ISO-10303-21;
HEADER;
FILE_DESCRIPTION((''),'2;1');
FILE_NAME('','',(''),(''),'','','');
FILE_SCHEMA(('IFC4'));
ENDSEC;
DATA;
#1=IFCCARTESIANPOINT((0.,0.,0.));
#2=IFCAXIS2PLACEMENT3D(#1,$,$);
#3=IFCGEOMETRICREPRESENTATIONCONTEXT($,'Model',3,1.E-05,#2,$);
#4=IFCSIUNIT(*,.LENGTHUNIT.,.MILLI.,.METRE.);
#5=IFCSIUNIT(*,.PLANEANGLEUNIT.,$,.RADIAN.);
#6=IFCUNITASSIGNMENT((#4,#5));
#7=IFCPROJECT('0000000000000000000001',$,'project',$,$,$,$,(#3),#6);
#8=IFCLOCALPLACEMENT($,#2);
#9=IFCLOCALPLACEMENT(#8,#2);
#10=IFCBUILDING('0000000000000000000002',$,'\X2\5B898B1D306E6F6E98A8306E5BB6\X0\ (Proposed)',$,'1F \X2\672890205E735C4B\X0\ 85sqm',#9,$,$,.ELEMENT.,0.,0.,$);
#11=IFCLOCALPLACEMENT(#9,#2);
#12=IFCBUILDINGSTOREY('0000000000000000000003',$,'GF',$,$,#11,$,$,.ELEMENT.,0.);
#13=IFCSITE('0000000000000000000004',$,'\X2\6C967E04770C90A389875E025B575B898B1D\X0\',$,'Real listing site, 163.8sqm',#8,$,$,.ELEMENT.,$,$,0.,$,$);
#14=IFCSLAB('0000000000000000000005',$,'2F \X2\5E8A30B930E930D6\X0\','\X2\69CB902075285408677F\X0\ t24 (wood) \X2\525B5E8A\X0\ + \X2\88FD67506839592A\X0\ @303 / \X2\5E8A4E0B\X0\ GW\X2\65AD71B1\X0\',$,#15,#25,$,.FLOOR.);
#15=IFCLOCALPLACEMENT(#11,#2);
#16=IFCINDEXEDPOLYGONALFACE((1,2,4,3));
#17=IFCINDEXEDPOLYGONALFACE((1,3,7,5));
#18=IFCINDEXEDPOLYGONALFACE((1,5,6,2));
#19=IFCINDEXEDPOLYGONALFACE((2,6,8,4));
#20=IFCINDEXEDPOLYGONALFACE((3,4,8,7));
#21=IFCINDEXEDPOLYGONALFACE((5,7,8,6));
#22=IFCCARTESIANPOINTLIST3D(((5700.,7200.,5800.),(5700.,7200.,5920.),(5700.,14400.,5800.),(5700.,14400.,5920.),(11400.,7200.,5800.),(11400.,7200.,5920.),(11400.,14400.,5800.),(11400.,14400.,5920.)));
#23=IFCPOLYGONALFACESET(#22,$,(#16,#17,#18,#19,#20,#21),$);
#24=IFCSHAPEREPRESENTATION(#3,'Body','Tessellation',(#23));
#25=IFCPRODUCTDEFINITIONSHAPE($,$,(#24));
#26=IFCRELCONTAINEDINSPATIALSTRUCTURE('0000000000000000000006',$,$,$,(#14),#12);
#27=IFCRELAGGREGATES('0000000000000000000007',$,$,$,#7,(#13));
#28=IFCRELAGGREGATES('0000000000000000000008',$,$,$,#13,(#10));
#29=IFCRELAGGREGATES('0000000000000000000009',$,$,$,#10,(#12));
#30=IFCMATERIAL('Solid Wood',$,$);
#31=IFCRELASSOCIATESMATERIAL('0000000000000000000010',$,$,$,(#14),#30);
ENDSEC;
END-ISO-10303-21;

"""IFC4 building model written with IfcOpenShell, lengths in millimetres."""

from ifc_helpers import new_model, si_unit, frame, frame_2d, origin, place, context, project, spatial, rectangle, extrude, material, element, save


model = new_model("IFC4")

# Units and contexts
model_context = context("Model", 3, precision=1e-05, world=origin())
ifc_project = project(units=[si_unit("LENGTHUNIT", "METRE", prefix="MILLI"), si_unit("PLANEANGLEUNIT", "RADIAN")], contexts=[model_context])

# Site, building, storey
site_placement = place(None, origin())
site = spatial("IfcSite", under=ifc_project, at=site_placement, Name="沖縄県那覇市字安謝", ObjectType="Real listing site, 163.8sqm", CompositionType="ELEMENT", RefElevation=0.0)
building_placement = place(site_placement, origin())
building = spatial("IfcBuilding", under=site, at=building_placement, Name="安謝の潮風の家 (Proposed)", ObjectType="1F 木造平屋 85sqm", CompositionType="ELEMENT", ElevationOfRefHeight=0.0, ElevationOfTerrain=0.0)
storey_placement = place(building_placement, origin())
storey = spatial("IfcBuildingStorey", under=building, at=storey_placement, Name="GF", CompositionType="ELEMENT", Elevation=0.0)

# Slab
ifc_material_1 = material(Name="Solid Wood")
slab_placement = place(storey_placement, frame((2850.0, 3600.0, 2900.0)))
element("IfcSlab", 1, at=slab_placement, inside=storey, material=ifc_material_1, Name="2F 床スラブ", Description="構造用合板 t24 (wood) 剛床 + 製材根太 @303 / 床下 GW断熱", PredefinedType="FLOOR", context=model_context, shape_type="SweptSolid", body=[
    extrude(rectangle(XDim=5700.0, YDim=7200.0, at=frame_2d((2850.0, 3600.0))), frame((2850.0, 3600.0, 2900.0)), (0.0, 0.0, 1.0), 120.0),
])

save(model, "model.ifc")
